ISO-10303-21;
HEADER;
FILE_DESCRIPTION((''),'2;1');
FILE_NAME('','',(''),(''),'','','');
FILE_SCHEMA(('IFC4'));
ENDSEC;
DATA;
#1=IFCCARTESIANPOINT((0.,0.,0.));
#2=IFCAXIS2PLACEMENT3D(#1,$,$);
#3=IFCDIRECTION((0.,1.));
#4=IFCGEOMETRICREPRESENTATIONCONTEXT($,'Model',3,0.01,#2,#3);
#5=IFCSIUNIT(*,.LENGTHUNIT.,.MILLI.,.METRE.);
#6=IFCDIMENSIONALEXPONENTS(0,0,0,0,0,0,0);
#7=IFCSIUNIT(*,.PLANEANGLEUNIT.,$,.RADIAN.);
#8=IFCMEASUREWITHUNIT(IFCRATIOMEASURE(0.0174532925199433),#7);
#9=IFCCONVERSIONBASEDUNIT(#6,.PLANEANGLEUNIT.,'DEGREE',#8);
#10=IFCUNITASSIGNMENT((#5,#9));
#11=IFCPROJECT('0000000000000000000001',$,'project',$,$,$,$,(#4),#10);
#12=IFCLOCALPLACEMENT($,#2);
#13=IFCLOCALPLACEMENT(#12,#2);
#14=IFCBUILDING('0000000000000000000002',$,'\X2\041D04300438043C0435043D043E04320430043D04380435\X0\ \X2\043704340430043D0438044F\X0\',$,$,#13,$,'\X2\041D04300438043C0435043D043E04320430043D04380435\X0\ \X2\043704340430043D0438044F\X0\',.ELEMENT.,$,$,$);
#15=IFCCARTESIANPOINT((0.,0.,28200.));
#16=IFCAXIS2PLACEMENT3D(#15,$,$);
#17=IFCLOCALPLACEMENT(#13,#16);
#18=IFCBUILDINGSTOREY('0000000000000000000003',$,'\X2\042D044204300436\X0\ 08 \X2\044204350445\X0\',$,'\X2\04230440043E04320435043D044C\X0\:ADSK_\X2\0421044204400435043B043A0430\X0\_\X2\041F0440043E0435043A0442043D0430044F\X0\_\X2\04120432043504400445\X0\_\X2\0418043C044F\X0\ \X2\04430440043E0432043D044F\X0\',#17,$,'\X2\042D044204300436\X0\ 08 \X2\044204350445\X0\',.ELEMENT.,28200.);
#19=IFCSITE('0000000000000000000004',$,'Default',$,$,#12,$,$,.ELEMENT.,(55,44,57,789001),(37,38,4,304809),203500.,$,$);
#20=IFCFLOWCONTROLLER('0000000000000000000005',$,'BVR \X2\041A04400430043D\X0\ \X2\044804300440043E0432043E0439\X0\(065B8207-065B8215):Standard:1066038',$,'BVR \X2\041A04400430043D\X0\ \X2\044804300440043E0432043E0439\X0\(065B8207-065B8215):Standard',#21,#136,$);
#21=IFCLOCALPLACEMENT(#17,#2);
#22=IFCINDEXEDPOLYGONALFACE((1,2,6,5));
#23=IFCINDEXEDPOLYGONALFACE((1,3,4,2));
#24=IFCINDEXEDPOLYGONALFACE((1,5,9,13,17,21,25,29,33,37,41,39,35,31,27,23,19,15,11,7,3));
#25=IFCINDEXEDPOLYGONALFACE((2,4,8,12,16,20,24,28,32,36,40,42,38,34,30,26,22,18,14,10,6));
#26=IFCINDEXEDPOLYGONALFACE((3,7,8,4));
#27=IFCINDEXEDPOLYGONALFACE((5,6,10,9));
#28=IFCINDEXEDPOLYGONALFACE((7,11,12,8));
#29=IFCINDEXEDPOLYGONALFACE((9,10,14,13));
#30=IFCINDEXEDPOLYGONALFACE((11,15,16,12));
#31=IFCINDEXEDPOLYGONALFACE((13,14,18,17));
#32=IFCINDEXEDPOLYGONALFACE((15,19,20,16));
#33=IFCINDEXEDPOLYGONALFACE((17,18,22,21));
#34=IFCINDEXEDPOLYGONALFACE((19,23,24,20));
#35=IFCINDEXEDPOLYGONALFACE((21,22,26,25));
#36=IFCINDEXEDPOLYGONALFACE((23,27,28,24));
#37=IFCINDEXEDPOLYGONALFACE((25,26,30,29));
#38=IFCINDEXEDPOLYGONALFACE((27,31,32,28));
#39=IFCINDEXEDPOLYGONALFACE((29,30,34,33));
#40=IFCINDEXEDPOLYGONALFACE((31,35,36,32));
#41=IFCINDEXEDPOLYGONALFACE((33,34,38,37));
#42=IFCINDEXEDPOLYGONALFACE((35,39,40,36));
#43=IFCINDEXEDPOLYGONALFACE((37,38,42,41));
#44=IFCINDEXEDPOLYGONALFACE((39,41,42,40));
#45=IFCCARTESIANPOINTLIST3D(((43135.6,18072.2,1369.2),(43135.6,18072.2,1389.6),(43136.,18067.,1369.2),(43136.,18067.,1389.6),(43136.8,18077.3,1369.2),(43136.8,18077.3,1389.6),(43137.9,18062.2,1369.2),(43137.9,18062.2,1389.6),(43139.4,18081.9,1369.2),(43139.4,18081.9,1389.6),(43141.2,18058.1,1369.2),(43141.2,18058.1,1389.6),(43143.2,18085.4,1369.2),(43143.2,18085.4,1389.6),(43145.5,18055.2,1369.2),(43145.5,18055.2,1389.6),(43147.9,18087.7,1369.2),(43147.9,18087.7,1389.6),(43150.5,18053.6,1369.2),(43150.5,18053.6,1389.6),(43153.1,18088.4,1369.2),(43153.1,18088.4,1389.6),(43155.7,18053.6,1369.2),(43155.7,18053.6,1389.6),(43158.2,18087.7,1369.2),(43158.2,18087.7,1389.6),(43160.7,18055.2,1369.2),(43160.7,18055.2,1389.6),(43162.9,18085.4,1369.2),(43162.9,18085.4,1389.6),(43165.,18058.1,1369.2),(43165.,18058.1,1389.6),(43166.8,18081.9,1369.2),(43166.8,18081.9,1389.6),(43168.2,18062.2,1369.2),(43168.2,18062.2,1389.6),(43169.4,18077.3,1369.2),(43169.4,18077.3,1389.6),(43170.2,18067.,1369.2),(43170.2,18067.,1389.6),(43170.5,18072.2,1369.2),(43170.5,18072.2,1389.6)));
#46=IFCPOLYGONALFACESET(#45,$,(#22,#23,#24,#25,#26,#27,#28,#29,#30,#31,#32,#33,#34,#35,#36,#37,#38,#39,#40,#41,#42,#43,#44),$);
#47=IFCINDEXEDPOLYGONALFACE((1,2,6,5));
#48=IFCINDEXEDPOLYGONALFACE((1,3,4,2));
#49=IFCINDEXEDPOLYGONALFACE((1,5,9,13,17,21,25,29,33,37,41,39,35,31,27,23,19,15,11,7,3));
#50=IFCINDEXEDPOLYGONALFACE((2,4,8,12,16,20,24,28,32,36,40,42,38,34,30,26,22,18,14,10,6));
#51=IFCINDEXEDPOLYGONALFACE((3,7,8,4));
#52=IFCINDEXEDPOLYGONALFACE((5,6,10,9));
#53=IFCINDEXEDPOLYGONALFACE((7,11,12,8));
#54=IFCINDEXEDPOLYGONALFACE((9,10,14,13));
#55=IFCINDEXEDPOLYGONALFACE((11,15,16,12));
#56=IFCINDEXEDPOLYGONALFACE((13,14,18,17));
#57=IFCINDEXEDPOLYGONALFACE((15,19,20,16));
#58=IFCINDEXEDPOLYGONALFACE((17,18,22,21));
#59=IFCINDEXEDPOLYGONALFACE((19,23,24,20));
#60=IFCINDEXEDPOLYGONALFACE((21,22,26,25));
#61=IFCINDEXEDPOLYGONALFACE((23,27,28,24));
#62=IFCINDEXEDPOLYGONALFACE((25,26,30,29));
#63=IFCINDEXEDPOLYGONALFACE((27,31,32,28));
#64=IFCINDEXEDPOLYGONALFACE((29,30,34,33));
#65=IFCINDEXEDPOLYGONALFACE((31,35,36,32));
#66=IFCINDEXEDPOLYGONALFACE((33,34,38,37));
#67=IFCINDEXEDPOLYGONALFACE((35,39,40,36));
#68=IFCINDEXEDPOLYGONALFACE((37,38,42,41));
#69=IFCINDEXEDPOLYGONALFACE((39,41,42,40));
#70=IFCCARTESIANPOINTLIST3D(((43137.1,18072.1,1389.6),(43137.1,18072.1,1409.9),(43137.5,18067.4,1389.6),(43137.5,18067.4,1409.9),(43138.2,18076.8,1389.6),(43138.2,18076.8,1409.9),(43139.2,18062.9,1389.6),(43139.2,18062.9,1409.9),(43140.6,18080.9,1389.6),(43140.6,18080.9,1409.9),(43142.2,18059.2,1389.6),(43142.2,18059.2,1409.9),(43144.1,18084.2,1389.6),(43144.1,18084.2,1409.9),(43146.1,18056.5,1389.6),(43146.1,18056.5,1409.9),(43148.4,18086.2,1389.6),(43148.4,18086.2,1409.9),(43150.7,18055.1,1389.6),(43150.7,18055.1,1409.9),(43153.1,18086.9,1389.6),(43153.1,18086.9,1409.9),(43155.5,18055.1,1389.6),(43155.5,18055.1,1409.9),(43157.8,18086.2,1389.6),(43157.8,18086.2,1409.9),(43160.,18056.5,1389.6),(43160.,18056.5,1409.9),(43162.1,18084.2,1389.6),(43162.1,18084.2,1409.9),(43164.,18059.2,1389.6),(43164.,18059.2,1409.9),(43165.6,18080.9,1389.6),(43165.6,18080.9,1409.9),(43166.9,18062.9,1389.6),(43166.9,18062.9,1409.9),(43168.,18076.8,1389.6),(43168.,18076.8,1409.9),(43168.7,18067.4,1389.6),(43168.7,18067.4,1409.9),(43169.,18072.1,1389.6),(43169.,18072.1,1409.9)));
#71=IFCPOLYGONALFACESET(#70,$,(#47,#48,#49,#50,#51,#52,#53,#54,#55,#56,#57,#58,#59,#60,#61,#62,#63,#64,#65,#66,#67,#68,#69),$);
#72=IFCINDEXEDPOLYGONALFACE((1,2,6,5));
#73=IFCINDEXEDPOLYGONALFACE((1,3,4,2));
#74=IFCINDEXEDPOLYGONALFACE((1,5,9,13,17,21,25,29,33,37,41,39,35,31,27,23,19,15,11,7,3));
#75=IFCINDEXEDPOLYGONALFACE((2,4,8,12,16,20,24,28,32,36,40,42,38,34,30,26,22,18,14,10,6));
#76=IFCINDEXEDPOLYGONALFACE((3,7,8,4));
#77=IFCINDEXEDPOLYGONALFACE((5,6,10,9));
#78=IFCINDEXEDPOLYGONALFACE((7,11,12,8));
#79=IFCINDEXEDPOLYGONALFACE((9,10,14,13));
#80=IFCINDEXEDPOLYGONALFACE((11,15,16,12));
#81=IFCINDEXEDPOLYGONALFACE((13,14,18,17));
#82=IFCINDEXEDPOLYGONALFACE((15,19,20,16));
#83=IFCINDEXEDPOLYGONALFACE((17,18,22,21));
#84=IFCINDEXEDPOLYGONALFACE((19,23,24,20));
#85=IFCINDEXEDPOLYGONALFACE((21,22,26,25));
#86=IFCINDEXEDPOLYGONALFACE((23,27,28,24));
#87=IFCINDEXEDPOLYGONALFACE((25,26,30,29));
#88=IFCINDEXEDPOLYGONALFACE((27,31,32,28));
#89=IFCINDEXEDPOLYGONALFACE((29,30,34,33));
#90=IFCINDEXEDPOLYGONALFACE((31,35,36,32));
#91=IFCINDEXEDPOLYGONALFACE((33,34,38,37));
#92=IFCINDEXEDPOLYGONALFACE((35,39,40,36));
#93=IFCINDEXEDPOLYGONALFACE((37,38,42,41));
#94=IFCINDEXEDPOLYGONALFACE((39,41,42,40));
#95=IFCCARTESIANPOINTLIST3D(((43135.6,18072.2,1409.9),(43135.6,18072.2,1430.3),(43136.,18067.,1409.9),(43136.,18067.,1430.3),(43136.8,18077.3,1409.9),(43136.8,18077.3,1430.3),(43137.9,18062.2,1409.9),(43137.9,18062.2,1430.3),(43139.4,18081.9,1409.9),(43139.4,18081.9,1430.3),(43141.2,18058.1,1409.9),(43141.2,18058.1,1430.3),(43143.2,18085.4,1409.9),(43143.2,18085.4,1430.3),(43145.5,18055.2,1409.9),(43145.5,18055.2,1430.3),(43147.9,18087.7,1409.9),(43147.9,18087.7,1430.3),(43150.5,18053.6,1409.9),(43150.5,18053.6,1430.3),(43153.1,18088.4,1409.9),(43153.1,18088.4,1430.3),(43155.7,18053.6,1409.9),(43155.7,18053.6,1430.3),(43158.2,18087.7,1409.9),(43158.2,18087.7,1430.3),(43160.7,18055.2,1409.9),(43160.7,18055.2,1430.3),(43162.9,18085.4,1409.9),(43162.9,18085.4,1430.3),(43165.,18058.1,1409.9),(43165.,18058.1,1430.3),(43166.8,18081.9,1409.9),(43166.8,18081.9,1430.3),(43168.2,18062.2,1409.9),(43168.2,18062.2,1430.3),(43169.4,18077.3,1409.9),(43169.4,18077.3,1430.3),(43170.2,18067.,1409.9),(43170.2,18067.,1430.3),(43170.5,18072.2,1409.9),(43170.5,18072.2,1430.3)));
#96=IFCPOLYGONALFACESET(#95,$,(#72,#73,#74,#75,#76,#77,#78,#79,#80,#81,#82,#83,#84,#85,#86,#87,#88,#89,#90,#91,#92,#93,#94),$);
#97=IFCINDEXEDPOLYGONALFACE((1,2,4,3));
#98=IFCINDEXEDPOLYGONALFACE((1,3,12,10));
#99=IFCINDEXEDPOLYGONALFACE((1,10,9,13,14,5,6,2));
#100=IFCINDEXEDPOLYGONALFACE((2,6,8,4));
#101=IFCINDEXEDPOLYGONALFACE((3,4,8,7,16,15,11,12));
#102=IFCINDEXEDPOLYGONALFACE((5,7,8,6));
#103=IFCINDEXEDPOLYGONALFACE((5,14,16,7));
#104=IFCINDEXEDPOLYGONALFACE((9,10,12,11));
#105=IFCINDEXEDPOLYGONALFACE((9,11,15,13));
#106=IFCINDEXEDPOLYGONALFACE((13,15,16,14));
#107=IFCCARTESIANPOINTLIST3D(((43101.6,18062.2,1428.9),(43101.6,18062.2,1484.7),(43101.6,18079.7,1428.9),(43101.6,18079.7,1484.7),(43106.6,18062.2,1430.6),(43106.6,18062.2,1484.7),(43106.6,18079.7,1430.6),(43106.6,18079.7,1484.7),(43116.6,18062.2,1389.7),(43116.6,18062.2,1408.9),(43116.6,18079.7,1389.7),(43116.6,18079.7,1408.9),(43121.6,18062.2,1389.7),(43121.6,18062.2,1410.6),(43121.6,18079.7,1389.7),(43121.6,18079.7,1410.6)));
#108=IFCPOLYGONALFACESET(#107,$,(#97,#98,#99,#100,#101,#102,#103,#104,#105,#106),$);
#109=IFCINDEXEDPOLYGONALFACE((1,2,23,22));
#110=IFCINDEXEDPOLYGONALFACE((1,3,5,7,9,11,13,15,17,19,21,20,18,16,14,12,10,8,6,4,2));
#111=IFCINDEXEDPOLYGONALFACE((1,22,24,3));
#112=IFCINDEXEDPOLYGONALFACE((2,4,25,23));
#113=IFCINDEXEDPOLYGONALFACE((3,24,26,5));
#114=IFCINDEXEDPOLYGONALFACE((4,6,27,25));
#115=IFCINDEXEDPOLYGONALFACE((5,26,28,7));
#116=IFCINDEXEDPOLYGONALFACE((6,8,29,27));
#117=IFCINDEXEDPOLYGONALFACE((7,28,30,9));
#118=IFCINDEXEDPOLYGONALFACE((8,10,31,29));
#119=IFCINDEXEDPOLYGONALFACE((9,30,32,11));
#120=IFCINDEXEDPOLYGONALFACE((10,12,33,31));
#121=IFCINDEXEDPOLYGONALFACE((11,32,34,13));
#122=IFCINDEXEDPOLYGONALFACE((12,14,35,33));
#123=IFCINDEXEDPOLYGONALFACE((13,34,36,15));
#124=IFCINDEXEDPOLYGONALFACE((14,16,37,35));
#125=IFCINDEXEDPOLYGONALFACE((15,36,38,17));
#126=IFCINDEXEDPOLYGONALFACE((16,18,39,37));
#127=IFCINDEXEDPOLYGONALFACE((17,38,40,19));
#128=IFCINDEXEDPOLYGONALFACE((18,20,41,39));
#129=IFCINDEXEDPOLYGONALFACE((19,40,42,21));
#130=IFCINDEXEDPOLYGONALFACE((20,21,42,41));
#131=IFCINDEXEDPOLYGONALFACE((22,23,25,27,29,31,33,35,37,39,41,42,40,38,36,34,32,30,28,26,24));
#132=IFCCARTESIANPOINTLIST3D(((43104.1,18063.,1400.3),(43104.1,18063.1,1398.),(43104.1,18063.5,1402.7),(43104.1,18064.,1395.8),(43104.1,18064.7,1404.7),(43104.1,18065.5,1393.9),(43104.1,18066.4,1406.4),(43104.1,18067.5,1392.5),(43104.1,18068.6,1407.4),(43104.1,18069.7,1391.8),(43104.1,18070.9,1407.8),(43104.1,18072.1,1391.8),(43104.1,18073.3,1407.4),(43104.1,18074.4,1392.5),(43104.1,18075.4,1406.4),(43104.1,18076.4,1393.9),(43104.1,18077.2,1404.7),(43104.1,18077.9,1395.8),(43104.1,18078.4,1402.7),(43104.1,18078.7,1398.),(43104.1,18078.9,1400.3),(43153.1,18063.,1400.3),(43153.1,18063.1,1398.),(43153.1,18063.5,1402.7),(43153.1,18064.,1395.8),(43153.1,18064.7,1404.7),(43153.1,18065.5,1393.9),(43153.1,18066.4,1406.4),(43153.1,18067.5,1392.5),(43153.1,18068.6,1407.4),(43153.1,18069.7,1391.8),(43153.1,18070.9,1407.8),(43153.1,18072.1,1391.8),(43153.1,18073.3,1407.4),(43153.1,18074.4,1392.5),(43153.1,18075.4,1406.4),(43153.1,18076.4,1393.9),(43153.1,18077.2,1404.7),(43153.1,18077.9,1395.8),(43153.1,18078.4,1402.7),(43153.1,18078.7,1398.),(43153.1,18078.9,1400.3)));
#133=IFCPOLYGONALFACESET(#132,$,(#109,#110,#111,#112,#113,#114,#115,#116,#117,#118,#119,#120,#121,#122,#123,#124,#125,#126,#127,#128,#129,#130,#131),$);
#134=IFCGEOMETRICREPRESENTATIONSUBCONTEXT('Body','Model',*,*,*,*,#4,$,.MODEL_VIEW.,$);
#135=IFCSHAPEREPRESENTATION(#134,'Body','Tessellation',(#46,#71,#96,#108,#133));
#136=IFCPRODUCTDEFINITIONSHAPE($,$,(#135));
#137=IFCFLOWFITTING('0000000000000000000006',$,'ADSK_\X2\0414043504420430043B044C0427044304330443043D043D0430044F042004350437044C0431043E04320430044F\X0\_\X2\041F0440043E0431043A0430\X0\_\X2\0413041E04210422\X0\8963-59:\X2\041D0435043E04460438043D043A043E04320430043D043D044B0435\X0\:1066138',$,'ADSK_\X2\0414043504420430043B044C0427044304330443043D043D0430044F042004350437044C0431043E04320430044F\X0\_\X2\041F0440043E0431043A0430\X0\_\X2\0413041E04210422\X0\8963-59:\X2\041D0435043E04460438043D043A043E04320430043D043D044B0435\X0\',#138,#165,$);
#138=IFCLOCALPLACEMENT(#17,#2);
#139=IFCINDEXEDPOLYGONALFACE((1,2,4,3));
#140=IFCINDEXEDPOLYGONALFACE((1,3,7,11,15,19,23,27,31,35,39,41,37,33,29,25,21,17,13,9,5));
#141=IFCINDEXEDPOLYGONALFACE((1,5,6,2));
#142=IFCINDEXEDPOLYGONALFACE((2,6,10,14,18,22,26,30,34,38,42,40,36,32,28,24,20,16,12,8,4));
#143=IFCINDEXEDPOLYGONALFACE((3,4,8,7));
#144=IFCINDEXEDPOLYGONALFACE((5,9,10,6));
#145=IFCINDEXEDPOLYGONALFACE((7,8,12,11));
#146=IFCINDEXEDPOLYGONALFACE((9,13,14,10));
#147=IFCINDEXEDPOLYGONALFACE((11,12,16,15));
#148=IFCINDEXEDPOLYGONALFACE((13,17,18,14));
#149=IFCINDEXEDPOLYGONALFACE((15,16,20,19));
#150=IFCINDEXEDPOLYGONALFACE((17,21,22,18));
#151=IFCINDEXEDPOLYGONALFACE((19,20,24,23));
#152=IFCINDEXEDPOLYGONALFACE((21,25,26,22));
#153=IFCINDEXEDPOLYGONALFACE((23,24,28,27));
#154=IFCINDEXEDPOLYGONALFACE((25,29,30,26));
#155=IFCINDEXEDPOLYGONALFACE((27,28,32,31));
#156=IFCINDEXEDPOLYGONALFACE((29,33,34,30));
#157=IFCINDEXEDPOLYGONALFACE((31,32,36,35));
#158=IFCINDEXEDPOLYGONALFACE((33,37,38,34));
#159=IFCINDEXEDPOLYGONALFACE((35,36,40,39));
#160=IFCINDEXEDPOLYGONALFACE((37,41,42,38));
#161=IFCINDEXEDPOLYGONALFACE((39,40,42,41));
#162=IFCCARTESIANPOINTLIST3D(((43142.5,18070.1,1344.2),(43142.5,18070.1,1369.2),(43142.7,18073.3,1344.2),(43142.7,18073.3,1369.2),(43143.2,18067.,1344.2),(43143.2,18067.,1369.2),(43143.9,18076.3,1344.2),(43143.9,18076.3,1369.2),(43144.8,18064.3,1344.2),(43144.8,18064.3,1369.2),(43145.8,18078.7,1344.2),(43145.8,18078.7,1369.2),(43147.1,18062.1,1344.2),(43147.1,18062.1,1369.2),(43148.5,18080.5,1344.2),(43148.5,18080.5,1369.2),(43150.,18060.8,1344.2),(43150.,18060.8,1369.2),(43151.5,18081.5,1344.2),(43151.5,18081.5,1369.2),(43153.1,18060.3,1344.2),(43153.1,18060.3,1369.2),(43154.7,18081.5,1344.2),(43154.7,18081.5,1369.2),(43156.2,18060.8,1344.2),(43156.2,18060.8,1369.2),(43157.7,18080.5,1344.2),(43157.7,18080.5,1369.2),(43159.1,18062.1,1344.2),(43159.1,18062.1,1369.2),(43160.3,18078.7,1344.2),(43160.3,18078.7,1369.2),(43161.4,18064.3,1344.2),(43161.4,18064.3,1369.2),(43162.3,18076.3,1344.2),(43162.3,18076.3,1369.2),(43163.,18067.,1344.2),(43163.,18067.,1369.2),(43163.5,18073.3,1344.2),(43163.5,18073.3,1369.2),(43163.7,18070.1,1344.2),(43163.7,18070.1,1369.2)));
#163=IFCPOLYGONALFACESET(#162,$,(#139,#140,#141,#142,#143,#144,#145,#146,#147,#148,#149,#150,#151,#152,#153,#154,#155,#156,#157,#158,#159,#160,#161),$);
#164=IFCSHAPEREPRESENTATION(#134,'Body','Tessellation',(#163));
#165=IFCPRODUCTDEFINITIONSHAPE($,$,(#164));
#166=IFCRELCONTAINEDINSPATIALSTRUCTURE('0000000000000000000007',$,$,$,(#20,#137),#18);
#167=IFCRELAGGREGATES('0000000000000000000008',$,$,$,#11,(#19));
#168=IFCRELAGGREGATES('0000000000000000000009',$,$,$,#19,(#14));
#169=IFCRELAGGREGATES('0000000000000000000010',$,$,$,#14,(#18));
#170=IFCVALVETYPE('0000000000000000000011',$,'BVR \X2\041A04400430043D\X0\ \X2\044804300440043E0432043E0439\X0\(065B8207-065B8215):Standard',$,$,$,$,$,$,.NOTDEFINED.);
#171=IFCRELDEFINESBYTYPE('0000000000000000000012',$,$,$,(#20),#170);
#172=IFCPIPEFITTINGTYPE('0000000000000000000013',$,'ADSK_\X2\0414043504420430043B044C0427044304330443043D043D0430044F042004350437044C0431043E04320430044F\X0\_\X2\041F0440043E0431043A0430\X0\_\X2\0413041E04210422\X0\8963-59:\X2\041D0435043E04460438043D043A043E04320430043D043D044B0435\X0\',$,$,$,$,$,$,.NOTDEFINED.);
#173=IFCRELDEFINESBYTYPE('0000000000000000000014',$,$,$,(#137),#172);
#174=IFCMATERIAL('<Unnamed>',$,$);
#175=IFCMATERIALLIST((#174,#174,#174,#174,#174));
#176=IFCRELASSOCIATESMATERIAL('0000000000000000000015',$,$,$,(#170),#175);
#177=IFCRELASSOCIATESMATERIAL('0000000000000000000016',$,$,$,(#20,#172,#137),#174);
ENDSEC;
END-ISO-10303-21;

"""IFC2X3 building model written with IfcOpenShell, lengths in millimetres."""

from ifc_helpers import new_model, entity, si_unit, converted_unit, direction, frame, origin, origin_2d_with_axis, place, context, subcontext, project, spatial, polyline, circle, outline, extrude, source, transform, mapped, material, material_list, type_object, type_shapes, element, save


model = new_model("IFC2X3")

# Units and contexts
model_context = context("Model", 3, precision=0.01, world=origin(), true_north=direction((0.0, 1.0)))
body_context = subcontext(model_context, "Body", "Model", "MODEL_VIEW")
ifc_project = project(units=[si_unit("LENGTHUNIT", "METRE", prefix="MILLI"), converted_unit("PLANEANGLEUNIT", "DEGREE", entity("IfcRatioMeasure", 0.0174532925199433), si_unit("PLANEANGLEUNIT", "RADIAN"), dimensions=[0, 0, 0, 0, 0, 0, 0])], contexts=[model_context])

# Site, building, storey
site_placement = place(None, origin())
site = spatial("IfcSite", under=ifc_project, at=site_placement, Name="Default", CompositionType="ELEMENT", RefLatitude=(55, 44, 57, 789001), RefLongitude=(37, 38, 4, 304809), RefElevation=203500.0)
building_placement = place(site_placement, origin())
building = spatial("IfcBuilding", under=site, at=building_placement, Name="Наименование здания", LongName="Наименование здания", CompositionType="ELEMENT")
storey_placement = place(building_placement, frame((0.0, 0.0, 28200.0)))
storey = spatial("IfcBuildingStorey", under=building, at=storey_placement, Name="Этаж 08 тех", ObjectType="Уровень:ADSK_Стрелка_Проектная_Вверх_Имя уровня", LongName="Этаж 08 тех", CompositionType="ELEMENT", Elevation=28200.0)

# Shared definitions
ifc_material = material(Name="<Unnamed>")

# Flow controller
ifc_material_list = material_list([ifc_material, ifc_material, ifc_material, ifc_material, ifc_material])
valve_type = type_object("IfcValveType", Name="BVR Кран шаровой(065B8207-065B8215):Standard", PredefinedType="NOTDEFINED", material=ifc_material_list)
shared_shape_1 = source(origin(), body_context, "Body", "SweptSolid", [
    extrude(circle(Radius=17.5, at=origin_2d_with_axis()), frame((-30.5, 0.0, 0.0), z_axis=(1.0, 0.0, 0.0), x_axis=(0.0, 1.0, 0.0)), (0.0, 0.0, 1.0), 20.3),
    extrude(circle(Radius=16.0, at=origin_2d_with_axis()), frame((-10.2, 0.0, 0.0), z_axis=(1.0, 0.0, 0.0), x_axis=(0.0, 1.0, 0.0)), (0.0, 0.0, 1.0), 20.3),
    extrude(circle(Radius=17.5, at=origin_2d_with_axis()), frame((10.2, 0.0, 0.0), z_axis=(1.0, 0.0, 0.0), x_axis=(0.0, 1.0, 0.0)), (0.0, 0.0, 1.0), 20.3),
    extrude(outline(polyline([(-38.8, -5.0), (-38.8, -10.0), (-17.9, -10.0), (2.1, 5.0), (56.2, 5.0), (56.2, 10.0), (0.4, 10.0), (-19.6, -5.0), (-38.8, -5.0)])), frame((28.8, -8.8, 41.5), z_axis=(0.0, -1.0, 0.0), x_axis=(1.0, 0.0, 0.0)), (0.0, 0.0, -1.0), 17.5),
    extrude(circle(Radius=8.0, at=origin_2d_with_axis()), origin(), (0.0, 0.0, 1.0), 49.0),
])
type_shapes(valve_type, [shared_shape_1])
for number, where, z_axis, x_axis, name in (
    (1, (43153.1, 18070.9, 1399.8), (-1.0, 0.0, 0.0), (0.0, 0.0, 1.0), "BVR Кран шаровой(065B8207-065B8215):Standard:1066038"),
):
    element("IfcFlowController", number, at=place(storey_placement, frame(where, z_axis=z_axis, x_axis=x_axis)), inside=storey, type_object=valve_type, material=ifc_material, Name=name, ObjectType="BVR Кран шаровой(065B8207-065B8215):Standard", context=body_context, shape_type="MappedRepresentation", body=[
        mapped(shared_shape_1, transform((0.0, 0.0, 0.0), scale=1.0)),
    ])

# Flow fitting
pipe_fitting_type_1 = type_object("IfcPipeFittingType", Name="ADSK_ДетальЧугуннаяРезьбовая_Пробка_ГОСТ8963-59:Неоцинкованные", PredefinedType="NOTDEFINED", material=ifc_material)
shared_shape_2 = source(origin(), body_context, "Body", "SweptSolid", [
    extrude(circle(Radius=10.7, at=origin_2d_with_axis()), frame((0.0, 0.0, 0.0), z_axis=(1.0, 0.0, 0.0), x_axis=(0.0, 1.0, 0.0)), (0.0, 0.0, 1.0), 25.0),
])
type_shapes(pipe_fitting_type_1, [shared_shape_2])
flow_fitting_placement = place(storey_placement, frame((43153.1, 18070.9, 1369.2), z_axis=(-1.0, 0.0, 0.0), x_axis=(0.0, 0.0, -1.0)))
element("IfcFlowFitting", 2, at=flow_fitting_placement, inside=storey, type_object=pipe_fitting_type_1, material=ifc_material, Name="ADSK_ДетальЧугуннаяРезьбовая_Пробка_ГОСТ8963-59:Неоцинкованные:1066138", ObjectType="ADSK_ДетальЧугуннаяРезьбовая_Пробка_ГОСТ8963-59:Неоцинкованные", context=body_context, shape_type="MappedRepresentation", body=[
    mapped(shared_shape_2, transform((0.0, 0.0, 0.0), scale=1.0)),
])

save(model, "model.ifc")
